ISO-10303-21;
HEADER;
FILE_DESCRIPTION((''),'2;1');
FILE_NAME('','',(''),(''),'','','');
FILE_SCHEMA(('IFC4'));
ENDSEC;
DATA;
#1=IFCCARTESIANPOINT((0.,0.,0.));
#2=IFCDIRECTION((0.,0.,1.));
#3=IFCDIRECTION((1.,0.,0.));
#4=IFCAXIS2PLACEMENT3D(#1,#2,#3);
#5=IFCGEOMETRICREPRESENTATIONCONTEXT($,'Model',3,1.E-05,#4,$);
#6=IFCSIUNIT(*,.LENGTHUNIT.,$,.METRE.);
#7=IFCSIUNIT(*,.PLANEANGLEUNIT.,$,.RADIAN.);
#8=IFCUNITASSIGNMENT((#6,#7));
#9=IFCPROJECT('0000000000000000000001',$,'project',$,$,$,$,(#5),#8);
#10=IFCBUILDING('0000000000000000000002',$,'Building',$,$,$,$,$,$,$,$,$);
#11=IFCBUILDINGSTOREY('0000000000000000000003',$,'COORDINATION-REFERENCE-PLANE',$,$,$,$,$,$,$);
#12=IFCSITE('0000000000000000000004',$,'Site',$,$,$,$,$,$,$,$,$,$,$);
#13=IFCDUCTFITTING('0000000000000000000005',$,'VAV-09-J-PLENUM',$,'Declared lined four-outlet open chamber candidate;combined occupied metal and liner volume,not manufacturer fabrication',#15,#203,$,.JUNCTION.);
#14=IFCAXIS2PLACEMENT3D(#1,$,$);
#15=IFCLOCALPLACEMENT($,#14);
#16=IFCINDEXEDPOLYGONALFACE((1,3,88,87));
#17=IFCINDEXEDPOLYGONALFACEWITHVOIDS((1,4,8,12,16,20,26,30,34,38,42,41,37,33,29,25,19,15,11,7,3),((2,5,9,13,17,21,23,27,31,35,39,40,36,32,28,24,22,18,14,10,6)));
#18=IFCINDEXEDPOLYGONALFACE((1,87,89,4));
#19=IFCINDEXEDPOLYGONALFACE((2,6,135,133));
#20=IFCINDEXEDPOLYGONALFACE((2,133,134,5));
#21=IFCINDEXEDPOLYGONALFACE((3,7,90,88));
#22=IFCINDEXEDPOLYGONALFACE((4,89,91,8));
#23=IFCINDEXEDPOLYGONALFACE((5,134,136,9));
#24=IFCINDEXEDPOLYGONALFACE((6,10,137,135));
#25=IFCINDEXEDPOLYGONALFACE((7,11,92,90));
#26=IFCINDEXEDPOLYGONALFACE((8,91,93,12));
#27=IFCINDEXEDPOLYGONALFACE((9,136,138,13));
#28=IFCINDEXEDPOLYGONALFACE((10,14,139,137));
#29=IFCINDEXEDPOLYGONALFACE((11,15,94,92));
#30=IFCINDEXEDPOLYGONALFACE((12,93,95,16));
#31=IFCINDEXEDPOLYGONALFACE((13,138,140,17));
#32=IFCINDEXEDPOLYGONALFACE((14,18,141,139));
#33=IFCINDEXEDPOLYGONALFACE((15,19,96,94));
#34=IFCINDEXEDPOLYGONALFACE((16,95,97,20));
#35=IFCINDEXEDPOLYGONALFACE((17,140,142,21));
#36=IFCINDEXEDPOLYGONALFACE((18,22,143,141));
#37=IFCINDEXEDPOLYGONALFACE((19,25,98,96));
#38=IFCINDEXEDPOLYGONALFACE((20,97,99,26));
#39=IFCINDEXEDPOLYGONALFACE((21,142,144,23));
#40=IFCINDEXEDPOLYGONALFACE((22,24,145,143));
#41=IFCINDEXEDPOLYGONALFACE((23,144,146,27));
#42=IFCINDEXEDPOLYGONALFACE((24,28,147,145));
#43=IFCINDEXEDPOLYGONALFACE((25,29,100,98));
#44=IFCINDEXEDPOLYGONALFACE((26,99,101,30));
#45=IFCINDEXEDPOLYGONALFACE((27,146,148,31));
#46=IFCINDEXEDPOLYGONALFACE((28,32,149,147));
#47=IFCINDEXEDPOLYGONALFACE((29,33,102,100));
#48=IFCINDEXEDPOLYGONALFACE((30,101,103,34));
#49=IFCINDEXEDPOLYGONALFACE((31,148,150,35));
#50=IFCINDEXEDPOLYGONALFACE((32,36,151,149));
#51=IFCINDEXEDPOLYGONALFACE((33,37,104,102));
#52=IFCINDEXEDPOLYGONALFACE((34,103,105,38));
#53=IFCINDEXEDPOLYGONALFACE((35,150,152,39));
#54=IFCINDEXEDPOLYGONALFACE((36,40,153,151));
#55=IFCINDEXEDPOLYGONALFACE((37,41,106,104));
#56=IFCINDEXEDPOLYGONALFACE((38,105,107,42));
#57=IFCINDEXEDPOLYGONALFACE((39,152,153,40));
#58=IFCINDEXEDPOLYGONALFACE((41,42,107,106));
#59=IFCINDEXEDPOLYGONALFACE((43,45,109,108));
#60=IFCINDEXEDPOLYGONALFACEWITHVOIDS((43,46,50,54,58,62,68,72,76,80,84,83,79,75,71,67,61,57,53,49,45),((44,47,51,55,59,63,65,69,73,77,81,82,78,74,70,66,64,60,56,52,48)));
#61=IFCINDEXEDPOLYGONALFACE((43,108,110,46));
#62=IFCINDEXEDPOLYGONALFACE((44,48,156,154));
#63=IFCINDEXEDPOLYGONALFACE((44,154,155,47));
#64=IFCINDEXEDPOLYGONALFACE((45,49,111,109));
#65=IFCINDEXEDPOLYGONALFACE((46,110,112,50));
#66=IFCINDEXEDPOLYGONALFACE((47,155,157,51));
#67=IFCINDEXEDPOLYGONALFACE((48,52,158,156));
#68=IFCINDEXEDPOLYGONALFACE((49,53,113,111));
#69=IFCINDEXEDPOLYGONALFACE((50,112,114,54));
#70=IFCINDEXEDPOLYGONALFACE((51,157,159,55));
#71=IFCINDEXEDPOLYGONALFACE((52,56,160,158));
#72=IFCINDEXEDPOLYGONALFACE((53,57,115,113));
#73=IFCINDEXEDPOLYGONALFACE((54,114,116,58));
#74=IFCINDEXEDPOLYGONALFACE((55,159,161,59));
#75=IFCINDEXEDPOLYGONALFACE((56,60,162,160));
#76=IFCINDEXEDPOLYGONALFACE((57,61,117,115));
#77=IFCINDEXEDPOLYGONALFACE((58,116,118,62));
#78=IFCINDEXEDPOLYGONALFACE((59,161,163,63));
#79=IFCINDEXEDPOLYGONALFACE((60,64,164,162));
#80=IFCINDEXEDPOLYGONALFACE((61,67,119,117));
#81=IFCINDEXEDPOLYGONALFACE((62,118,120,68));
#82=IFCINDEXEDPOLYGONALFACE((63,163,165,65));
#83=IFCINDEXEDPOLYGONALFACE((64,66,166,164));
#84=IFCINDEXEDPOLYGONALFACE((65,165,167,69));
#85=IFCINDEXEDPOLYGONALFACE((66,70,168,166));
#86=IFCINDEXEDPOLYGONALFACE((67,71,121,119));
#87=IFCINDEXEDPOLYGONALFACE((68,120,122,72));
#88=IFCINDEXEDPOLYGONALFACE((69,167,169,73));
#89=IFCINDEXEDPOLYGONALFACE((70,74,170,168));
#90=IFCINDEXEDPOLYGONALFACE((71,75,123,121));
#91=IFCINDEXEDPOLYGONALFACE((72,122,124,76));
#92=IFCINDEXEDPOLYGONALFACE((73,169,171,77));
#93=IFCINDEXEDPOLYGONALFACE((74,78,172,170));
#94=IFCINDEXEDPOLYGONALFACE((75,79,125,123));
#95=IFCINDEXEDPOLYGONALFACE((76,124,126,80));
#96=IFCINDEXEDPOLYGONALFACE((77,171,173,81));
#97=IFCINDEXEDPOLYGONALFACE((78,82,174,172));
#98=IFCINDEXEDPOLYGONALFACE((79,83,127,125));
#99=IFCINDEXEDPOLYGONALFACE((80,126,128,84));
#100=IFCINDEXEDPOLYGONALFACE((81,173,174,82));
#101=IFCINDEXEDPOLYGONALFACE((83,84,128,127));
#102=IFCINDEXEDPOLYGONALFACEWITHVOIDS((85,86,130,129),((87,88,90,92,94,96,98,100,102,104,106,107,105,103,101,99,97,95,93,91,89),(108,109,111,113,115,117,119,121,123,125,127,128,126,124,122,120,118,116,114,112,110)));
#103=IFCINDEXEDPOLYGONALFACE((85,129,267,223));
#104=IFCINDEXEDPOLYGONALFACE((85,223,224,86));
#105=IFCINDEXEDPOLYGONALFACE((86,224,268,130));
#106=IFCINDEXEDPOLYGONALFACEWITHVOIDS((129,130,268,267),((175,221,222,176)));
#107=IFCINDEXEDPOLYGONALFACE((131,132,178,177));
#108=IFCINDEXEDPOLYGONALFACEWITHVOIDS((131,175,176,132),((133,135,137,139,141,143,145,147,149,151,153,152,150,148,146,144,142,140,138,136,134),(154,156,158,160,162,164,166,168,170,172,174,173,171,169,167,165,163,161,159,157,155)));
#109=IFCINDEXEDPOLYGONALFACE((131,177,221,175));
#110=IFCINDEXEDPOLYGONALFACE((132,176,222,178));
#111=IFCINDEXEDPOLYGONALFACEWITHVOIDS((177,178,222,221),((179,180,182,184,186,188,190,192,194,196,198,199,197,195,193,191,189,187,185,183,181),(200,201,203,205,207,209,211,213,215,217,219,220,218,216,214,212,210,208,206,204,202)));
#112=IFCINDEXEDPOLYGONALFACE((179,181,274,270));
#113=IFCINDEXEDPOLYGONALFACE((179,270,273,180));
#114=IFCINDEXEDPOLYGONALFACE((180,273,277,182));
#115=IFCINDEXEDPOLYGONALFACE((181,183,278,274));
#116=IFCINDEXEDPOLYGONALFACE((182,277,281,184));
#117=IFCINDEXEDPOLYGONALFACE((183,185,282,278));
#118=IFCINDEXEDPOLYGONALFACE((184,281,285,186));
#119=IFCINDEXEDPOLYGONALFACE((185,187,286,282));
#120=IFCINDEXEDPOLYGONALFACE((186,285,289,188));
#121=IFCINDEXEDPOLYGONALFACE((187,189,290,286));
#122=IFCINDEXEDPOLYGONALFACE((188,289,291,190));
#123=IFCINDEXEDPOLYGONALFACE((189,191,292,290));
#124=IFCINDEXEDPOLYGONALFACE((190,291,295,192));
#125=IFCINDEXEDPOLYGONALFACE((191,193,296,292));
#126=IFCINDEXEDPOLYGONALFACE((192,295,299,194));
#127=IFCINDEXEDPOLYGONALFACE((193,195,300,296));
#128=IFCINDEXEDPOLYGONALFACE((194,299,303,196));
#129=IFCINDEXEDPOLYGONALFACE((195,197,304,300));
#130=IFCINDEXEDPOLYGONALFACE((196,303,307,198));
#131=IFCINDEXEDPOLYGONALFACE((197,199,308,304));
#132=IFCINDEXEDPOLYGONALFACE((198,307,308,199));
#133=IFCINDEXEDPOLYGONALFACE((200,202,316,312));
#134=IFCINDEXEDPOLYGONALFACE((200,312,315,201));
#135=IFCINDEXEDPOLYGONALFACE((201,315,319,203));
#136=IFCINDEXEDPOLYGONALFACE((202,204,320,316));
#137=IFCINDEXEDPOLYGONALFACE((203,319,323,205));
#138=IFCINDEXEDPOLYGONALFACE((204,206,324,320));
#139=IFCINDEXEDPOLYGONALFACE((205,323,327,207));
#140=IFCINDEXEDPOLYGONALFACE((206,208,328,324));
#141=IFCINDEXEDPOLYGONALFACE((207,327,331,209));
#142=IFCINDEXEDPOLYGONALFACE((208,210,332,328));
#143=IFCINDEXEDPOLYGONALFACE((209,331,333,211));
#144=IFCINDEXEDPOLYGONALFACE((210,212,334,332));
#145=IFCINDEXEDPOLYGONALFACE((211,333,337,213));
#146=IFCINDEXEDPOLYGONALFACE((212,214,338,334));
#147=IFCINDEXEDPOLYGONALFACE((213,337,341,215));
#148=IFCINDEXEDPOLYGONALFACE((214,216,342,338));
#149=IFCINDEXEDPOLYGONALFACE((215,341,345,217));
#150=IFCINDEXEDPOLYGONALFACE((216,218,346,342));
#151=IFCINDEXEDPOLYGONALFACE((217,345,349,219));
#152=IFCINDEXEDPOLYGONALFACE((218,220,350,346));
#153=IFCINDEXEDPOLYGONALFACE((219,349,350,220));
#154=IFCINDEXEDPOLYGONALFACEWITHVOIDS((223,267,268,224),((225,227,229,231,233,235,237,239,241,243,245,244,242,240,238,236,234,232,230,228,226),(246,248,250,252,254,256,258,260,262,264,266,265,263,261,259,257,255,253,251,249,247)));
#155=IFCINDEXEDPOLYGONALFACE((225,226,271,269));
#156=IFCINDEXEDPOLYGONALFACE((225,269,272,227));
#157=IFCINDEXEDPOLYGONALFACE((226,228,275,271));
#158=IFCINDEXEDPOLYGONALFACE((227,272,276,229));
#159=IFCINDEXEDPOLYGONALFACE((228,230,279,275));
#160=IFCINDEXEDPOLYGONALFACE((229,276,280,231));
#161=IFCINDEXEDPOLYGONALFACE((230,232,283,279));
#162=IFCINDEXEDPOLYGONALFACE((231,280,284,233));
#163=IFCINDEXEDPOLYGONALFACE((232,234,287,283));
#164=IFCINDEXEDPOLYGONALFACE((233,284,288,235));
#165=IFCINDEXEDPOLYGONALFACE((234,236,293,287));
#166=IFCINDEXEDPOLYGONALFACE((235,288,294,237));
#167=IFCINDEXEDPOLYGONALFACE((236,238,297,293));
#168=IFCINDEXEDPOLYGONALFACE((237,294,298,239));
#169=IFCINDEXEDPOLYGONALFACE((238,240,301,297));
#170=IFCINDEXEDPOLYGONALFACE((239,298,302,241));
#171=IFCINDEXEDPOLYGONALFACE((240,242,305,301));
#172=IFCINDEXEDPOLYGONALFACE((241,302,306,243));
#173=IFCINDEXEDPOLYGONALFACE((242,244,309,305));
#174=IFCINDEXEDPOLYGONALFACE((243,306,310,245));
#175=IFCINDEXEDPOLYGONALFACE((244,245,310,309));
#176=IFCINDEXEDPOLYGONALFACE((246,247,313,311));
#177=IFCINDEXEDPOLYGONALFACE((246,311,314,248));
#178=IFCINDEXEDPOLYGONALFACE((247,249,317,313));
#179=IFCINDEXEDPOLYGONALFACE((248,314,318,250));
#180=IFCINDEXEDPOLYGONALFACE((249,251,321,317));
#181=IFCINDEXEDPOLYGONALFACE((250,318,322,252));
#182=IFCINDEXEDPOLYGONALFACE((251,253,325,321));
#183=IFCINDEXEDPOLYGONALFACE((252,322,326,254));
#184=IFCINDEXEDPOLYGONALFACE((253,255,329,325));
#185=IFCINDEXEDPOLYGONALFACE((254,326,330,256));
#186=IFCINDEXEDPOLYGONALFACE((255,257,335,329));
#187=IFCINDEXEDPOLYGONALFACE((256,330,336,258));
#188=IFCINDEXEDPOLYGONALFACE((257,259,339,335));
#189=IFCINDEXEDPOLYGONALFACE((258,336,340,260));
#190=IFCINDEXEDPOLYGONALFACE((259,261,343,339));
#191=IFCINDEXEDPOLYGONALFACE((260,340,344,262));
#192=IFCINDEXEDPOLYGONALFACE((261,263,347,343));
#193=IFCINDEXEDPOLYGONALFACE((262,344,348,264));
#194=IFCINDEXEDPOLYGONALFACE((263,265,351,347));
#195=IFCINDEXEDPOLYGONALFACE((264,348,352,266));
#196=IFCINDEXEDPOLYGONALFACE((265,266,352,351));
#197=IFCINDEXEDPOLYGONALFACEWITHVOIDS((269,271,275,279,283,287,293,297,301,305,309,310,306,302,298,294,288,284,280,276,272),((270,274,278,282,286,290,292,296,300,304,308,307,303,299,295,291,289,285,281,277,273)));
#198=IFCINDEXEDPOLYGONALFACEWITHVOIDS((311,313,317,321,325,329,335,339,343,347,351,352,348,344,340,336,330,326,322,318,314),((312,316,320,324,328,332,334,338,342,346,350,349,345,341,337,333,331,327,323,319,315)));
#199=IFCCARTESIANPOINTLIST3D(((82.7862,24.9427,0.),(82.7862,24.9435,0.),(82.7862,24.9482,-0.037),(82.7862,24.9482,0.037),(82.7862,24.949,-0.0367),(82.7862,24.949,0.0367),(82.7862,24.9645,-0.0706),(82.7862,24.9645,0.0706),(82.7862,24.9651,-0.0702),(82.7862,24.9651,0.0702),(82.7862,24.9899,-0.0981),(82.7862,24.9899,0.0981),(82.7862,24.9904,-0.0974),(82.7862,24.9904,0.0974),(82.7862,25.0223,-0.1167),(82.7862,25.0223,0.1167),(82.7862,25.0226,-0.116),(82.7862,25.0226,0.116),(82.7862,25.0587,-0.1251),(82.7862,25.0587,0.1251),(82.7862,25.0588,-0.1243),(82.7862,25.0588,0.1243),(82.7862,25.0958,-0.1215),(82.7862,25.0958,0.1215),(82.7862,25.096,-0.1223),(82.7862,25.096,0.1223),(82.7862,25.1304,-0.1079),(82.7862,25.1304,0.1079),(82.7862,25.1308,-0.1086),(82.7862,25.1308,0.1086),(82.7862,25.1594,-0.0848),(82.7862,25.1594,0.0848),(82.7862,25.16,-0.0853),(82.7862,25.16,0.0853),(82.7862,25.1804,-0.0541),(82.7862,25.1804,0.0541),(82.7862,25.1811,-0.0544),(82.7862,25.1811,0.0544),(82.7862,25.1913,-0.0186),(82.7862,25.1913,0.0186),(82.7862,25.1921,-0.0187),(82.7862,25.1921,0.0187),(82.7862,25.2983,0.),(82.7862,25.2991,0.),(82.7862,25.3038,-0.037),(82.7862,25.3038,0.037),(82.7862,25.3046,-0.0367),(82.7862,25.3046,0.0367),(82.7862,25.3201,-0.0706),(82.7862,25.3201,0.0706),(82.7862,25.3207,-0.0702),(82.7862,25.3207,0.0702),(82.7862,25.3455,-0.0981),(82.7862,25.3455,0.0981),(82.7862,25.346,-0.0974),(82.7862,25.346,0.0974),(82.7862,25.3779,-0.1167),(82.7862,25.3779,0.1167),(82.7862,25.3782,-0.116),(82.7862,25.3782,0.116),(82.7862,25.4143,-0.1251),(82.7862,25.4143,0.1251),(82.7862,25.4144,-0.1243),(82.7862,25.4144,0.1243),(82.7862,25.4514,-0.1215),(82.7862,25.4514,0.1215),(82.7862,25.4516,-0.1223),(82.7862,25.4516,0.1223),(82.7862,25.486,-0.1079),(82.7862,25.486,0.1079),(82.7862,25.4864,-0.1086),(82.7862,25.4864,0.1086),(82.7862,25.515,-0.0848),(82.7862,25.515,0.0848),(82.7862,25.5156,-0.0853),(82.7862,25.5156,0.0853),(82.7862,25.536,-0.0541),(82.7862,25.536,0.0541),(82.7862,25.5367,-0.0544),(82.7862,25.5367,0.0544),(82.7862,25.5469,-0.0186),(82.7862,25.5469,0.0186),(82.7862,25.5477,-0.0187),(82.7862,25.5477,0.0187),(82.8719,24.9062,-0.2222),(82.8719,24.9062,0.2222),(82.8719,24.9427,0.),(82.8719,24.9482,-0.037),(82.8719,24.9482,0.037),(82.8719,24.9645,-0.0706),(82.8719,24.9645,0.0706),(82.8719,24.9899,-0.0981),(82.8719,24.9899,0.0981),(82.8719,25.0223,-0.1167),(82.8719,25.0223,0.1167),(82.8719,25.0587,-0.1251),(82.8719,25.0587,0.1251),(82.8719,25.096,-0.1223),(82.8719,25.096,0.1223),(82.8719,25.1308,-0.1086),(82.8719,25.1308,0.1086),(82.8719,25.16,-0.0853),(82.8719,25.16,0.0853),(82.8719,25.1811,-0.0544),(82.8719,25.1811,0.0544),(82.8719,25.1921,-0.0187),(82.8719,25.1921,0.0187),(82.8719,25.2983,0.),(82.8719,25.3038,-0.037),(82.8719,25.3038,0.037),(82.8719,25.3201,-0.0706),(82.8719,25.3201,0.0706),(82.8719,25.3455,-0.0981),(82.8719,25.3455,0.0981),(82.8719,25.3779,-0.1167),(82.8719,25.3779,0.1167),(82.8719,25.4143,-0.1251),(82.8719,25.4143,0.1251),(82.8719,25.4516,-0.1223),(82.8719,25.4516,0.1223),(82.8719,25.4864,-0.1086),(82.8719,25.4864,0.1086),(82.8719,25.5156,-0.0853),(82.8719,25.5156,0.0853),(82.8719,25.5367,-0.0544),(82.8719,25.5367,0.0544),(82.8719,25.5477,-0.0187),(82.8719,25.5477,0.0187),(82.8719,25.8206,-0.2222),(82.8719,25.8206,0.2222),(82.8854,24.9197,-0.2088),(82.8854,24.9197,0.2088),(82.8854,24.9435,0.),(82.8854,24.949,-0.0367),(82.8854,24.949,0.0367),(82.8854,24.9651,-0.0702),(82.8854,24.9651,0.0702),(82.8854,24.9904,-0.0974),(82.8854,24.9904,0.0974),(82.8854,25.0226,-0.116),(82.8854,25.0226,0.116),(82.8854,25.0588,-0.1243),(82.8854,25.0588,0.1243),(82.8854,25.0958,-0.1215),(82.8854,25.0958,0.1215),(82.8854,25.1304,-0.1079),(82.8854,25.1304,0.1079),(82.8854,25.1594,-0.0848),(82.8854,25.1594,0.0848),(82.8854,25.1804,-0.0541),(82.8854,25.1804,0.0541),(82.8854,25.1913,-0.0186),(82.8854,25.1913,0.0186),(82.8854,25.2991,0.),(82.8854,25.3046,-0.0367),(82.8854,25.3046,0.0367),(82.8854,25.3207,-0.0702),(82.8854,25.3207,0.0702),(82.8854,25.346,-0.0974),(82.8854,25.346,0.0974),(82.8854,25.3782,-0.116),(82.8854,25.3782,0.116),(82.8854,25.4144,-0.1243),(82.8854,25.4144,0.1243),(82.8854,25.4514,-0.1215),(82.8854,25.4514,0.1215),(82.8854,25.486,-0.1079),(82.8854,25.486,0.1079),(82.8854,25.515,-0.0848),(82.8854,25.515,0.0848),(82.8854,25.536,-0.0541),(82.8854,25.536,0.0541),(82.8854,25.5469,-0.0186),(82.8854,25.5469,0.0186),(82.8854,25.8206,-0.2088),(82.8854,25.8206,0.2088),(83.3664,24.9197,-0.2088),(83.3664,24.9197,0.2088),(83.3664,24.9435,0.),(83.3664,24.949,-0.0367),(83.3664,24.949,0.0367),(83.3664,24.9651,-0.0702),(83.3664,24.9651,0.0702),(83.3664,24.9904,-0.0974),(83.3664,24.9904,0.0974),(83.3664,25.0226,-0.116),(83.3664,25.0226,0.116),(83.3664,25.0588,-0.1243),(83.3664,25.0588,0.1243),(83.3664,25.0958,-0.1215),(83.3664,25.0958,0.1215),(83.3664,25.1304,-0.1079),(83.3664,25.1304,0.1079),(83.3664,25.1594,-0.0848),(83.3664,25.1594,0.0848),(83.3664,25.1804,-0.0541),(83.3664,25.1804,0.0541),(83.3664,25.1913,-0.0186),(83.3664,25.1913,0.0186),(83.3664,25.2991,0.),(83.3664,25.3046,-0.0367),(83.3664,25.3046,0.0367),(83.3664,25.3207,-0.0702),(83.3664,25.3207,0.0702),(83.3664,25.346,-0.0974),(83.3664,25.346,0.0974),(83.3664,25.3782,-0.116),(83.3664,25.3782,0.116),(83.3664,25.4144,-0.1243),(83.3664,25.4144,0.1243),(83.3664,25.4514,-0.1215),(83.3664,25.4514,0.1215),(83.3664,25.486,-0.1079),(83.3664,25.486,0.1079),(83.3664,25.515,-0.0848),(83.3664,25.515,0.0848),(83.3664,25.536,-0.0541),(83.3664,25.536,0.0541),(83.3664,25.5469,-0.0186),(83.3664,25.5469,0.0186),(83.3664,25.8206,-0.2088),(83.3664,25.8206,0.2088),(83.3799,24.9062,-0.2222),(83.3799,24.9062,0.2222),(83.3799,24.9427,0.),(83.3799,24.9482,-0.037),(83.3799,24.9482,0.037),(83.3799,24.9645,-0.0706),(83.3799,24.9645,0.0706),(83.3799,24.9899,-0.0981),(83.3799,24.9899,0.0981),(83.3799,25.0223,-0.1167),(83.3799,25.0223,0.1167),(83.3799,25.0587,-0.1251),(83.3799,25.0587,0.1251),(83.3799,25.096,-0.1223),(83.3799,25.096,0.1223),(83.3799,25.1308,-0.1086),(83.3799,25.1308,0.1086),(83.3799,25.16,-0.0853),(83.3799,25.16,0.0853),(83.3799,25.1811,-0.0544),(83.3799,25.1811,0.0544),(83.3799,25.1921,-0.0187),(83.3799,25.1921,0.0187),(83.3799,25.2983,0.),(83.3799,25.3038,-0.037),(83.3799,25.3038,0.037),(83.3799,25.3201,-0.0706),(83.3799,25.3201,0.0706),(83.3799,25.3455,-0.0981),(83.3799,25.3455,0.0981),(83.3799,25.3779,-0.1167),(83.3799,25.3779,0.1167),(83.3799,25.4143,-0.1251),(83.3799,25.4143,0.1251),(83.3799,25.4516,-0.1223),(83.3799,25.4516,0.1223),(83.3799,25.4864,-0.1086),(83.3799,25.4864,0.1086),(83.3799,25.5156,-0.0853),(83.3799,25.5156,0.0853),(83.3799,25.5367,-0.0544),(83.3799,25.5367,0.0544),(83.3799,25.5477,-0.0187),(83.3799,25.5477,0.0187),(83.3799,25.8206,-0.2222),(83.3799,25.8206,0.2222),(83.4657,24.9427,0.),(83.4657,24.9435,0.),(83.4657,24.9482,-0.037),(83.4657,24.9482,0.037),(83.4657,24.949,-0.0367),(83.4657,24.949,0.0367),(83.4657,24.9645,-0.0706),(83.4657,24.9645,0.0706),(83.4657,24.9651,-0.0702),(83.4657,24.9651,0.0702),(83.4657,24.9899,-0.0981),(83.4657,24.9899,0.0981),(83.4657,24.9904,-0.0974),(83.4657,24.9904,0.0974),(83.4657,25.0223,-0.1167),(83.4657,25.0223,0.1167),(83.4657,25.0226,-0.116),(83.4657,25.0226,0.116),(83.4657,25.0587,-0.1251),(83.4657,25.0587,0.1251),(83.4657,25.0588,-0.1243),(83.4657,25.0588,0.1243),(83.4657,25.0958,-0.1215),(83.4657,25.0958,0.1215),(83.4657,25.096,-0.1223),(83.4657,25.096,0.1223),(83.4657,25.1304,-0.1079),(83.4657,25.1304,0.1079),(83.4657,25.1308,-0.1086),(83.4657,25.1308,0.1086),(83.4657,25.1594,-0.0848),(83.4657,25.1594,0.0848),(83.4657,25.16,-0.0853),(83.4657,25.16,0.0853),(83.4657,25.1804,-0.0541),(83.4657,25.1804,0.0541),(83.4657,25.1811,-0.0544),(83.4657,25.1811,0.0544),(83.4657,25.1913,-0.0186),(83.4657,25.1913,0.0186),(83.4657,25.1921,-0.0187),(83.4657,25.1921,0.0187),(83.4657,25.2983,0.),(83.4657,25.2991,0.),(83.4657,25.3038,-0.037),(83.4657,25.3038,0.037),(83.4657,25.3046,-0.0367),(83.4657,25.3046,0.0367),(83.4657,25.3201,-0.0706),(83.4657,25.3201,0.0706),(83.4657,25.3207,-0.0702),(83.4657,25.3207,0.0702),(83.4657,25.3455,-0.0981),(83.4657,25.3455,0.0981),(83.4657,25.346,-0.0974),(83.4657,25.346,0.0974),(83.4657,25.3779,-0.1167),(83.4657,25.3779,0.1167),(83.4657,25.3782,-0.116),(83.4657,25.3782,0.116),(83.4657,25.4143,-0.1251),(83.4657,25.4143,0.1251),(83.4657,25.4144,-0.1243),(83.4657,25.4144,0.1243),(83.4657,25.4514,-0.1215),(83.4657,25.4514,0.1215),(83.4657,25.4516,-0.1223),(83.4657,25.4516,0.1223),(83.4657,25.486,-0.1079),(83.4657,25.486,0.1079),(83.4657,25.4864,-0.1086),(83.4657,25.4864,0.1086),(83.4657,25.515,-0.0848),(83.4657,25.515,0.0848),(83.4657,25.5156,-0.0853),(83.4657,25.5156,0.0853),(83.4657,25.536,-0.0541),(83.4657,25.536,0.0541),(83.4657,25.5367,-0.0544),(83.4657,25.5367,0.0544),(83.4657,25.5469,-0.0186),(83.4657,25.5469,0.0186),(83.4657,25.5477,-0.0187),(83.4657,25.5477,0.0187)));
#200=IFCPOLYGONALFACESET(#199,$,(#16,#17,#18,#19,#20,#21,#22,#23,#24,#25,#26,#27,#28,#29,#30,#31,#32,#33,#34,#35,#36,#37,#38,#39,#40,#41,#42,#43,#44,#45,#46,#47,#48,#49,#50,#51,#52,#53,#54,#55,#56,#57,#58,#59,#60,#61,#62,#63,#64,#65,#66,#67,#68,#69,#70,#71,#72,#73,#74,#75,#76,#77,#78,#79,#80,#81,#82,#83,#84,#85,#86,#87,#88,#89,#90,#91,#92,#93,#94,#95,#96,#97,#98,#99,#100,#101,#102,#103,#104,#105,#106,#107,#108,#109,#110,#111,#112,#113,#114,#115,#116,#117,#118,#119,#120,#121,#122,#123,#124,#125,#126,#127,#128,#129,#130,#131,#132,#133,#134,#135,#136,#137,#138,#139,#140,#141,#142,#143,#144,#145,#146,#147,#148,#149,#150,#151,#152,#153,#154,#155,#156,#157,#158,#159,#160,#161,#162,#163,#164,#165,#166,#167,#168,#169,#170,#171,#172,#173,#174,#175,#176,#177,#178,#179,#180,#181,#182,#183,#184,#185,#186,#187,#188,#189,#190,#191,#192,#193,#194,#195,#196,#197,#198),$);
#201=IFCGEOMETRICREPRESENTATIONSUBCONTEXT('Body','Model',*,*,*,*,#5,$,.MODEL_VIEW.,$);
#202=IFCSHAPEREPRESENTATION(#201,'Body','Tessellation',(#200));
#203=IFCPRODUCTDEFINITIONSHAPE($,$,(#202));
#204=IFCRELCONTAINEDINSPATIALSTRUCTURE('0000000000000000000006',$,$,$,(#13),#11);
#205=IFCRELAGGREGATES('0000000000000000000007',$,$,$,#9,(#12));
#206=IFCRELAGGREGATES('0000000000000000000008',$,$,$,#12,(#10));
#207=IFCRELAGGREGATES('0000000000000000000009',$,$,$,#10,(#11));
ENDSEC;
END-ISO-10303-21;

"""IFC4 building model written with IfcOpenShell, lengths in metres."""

from ifc_helpers import new_model, si_unit, frame, origin_with_axes, place, context, subcontext, project, spatial, rectangle, circle, extrude, boolean, element, save


model = new_model("IFC4")

# Units and contexts
model_context = context("Model", 3, precision=1e-05, world=origin_with_axes())
body_context_1 = subcontext(model_context, "Body", "Model", "MODEL_VIEW")
ifc_project = project(units=[si_unit("LENGTHUNIT", "METRE"), si_unit("PLANEANGLEUNIT", "RADIAN")], contexts=[model_context])

# Site, building, storey
site = spatial("IfcSite", under=ifc_project, Name="Site")
building = spatial("IfcBuilding", under=site, Name="Building")
storey = spatial("IfcBuildingStorey", under=building, Name="COORDINATION-REFERENCE-PLANE")

# Duct fitting
duct_fitting_1_placement = place(None, frame((82.8719, 24.9062, -0.2223), z_axis=(0.0, 0.0, 1.0), x_axis=(1.0, 0.0, 0.0)))
solid_1 = boolean("UNION", boolean("UNION", boolean("UNION", boolean("UNION", extrude(rectangle(XDim=0.481, YDim=0.4175), frame((0.254, 0.9244, 0.2223), z_axis=(0.0, -1.0, 0.0), x_axis=(1.0, 0.0, 0.0)), (0.0, 0.0, 1.0), 0.9109), extrude(circle(Radius=0.1246), frame((0.0235, 0.5175, 0.2223), z_axis=(-1.0, 0.0, 0.0), x_axis=(0.0, -1.0, 0.0)), (0.0, 0.0, 1.0), 0.1192)), extrude(circle(Radius=0.1246), frame((0.4845, 0.5175, 0.2223), z_axis=(1.0, 0.0, 0.0), x_axis=(0.0, -1.0, 0.0)), (0.0, 0.0, 1.0), 0.1192)), extrude(circle(Radius=0.1246), frame((0.0235, 0.1619, 0.2223), z_axis=(-1.0, 0.0, 0.0), x_axis=(0.0, -1.0, 0.0)), (0.0, 0.0, 1.0), 0.1192)), extrude(circle(Radius=0.1246), frame((0.4845, 0.1619, 0.2223), z_axis=(1.0, 0.0, 0.0), x_axis=(0.0, -1.0, 0.0)), (0.0, 0.0, 1.0), 0.1192))
element("IfcDuctFitting", 1, at=duct_fitting_1_placement, inside=storey, Name="VAV-09-J-PLENUM", ObjectType="Declared lined four-outlet open chamber candidate;combined occupied metal and liner volume,not manufacturer fabrication", PredefinedType="JUNCTION", context=body_context_1, shape_type="CSG", body=[
    boolean("DIFFERENCE", boolean("UNION", boolean("UNION", boolean("UNION", boolean("UNION", extrude(rectangle(XDim=0.508, YDim=0.4445), frame((0.254, 0.9144, 0.2223), z_axis=(0.0, -1.0, 0.0), x_axis=(1.0, 0.0, 0.0)), (0.0, 0.0, 1.0), 0.9144), extrude(circle(Radius=0.1254), frame((0.0235, 0.5175, 0.2223), z_axis=(-1.0, 0.0, 0.0), x_axis=(0.0, -1.0, 0.0)), (0.0, 0.0, 1.0), 0.1092)), extrude(circle(Radius=0.1254), frame((0.4845, 0.5175, 0.2223), z_axis=(1.0, 0.0, 0.0), x_axis=(0.0, -1.0, 0.0)), (0.0, 0.0, 1.0), 0.1092)), extrude(circle(Radius=0.1254), frame((0.0235, 0.1619, 0.2223), z_axis=(-1.0, 0.0, 0.0), x_axis=(0.0, -1.0, 0.0)), (0.0, 0.0, 1.0), 0.1092)), extrude(circle(Radius=0.1254), frame((0.4845, 0.1619, 0.2223), z_axis=(1.0, 0.0, 0.0), x_axis=(0.0, -1.0, 0.0)), (0.0, 0.0, 1.0), 0.1092)), solid_1),
])

save(model, "model.ifc")
